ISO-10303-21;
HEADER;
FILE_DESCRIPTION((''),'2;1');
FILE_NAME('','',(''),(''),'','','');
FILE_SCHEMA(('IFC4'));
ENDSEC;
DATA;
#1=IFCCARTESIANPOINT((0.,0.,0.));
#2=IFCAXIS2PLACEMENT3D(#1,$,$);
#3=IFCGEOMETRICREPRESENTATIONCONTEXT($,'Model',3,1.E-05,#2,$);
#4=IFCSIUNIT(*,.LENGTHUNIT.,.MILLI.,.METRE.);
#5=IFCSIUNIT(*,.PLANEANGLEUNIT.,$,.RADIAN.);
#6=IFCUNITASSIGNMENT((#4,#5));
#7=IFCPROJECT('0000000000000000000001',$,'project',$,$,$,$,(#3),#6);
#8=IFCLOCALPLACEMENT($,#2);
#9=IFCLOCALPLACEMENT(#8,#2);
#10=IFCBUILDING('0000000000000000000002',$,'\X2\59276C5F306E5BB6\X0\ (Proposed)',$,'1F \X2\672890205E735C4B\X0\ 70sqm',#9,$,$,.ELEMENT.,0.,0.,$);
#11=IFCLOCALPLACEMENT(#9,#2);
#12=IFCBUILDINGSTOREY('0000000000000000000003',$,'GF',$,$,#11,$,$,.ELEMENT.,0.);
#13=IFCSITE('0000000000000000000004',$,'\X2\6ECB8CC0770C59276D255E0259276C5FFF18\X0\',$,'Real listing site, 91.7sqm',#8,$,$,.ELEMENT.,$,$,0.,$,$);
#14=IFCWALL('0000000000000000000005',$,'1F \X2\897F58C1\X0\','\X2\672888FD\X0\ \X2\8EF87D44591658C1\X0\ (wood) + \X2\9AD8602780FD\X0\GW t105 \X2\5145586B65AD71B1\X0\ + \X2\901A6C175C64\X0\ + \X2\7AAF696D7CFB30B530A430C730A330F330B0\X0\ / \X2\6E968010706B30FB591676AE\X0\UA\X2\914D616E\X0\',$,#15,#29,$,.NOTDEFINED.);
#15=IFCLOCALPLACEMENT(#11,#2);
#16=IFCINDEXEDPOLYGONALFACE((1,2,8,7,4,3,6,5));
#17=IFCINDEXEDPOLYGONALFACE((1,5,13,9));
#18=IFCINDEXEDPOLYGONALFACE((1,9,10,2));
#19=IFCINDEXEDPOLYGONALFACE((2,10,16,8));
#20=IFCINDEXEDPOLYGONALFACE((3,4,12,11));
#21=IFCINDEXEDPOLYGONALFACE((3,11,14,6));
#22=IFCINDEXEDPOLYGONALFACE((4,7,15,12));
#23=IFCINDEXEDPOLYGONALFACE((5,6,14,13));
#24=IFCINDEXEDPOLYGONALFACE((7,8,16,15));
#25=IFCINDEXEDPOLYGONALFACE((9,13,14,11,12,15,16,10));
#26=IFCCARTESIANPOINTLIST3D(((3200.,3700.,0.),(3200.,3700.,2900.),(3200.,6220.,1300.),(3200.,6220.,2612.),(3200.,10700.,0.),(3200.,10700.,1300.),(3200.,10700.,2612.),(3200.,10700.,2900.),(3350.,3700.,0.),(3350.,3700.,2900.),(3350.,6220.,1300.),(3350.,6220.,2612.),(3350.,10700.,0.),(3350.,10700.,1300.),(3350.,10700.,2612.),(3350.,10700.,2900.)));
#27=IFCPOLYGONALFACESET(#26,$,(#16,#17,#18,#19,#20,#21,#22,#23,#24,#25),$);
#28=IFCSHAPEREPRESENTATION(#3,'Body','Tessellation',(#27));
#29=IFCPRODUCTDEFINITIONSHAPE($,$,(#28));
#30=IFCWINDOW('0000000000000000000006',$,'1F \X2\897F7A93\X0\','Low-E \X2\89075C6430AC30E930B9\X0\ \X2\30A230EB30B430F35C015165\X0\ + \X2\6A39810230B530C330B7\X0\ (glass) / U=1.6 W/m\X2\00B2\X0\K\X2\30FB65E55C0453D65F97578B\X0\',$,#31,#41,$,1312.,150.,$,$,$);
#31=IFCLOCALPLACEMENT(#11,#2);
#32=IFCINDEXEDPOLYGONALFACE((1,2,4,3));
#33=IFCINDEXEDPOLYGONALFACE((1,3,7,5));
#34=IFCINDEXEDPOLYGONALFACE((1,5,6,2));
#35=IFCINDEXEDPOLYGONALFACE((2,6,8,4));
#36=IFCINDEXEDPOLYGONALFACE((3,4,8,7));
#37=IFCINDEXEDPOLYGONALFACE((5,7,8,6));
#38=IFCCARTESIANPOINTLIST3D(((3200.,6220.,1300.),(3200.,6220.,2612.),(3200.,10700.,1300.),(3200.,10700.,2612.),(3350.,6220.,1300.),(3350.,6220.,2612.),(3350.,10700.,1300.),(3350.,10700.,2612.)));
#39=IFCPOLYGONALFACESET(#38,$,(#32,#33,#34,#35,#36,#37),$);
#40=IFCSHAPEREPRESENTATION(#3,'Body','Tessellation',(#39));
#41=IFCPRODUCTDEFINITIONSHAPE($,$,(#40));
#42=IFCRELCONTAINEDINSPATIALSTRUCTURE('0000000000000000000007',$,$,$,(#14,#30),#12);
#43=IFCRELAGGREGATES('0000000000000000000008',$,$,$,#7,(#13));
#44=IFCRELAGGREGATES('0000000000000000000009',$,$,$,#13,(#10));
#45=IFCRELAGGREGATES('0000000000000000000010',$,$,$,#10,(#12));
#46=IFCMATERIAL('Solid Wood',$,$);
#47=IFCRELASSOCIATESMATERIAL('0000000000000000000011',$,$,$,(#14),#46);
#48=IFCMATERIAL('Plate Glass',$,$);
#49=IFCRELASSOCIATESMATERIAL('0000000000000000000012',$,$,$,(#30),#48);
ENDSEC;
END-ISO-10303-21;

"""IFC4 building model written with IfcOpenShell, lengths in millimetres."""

from ifc_helpers import new_model, si_unit, frame, frame_2d, origin, place, context, project, spatial, rectangle, extrude, material, element, fill, save


model = new_model("IFC4")

# Units and contexts
model_context = context("Model", 3, precision=1e-05, world=origin())
ifc_project = project(units=[si_unit("LENGTHUNIT", "METRE", prefix="MILLI"), si_unit("PLANEANGLEUNIT", "RADIAN")], contexts=[model_context])

# Site, building, storey
site_placement = place(None, origin())
site = spatial("IfcSite", under=ifc_project, at=site_placement, Name="滋賀県大津市大江８", ObjectType="Real listing site, 91.7sqm", CompositionType="ELEMENT", RefElevation=0.0)
building_placement = place(site_placement, origin())
building = spatial("IfcBuilding", under=site, at=building_placement, Name="大江の家 (Proposed)", ObjectType="1F 木造平屋 70sqm", CompositionType="ELEMENT", ElevationOfRefHeight=0.0, ElevationOfTerrain=0.0)
storey_placement = place(building_placement, origin())
storey = spatial("IfcBuildingStorey", under=building, at=storey_placement, Name="GF", CompositionType="ELEMENT", Elevation=0.0)

# Shared definitions
ifc_material_1 = material(Name="Solid Wood")

# Shared definitions
ifc_material_2 = material(Name="Plate Glass")

# Wall, opening, window
wall_1_placement = place(storey_placement, frame((1600.0, 1850.0, 0.0)))
wall_1 = element("IfcWall", 1, at=wall_1_placement, inside=storey, material=ifc_material_1, Name="1F 西壁", Description="木製 軸組外壁 (wood) + 高性能GW t105 充填断熱 + 通気層 + 窯業系サイディング / 準耐火・外皮UA配慮", PredefinedType="NOTDEFINED", context=model_context, shape_type="SweptSolid", body=[
    extrude(rectangle(XDim=150.0, YDim=7000.0, at=frame_2d((75.0, 3500.0))), frame((1600.0, 1850.0, 0.0)), (0.0, 0.0, 1.0), 2900.0),
])
opening_1_placement = place(storey_placement, frame((1600.0, 3110.0, 650.0)))
opening_1 = element("IfcOpeningElement", 2, at=opening_1_placement, cuts=wall_1, PredefinedType="NOTDEFINED", context=model_context, shape_type="SweptSolid", body=[
    extrude(rectangle(XDim=150.0, YDim=4480.0, at=frame_2d((75.0, 2240.0))), frame((1600.0, 3110.0, 650.0)), (0.0, 0.0, 1.0), 1312.0),
])
window_1_placement = place(storey_placement, frame((1600.0, 3110.0, 650.0)))
window_1 = element("IfcWindow", 3, at=window_1_placement, inside=storey, material=ifc_material_2, Name="1F 西窓", Description="Low-E 複層ガラス アルゴン封入 + 樹脂サッシ (glass) / U=1.6 W/m²K・日射取得型", OverallHeight=1312.0, OverallWidth=150.0, context=model_context, shape_type="SweptSolid", body=[
    extrude(rectangle(XDim=150.0, YDim=4480.0, at=frame_2d((75.0, 2240.0))), frame((1600.0, 3110.0, 650.0)), (0.0, 0.0, 1.0), 1312.0),
])
fill(opening_1, window_1)

save(model, "model.ifc")
